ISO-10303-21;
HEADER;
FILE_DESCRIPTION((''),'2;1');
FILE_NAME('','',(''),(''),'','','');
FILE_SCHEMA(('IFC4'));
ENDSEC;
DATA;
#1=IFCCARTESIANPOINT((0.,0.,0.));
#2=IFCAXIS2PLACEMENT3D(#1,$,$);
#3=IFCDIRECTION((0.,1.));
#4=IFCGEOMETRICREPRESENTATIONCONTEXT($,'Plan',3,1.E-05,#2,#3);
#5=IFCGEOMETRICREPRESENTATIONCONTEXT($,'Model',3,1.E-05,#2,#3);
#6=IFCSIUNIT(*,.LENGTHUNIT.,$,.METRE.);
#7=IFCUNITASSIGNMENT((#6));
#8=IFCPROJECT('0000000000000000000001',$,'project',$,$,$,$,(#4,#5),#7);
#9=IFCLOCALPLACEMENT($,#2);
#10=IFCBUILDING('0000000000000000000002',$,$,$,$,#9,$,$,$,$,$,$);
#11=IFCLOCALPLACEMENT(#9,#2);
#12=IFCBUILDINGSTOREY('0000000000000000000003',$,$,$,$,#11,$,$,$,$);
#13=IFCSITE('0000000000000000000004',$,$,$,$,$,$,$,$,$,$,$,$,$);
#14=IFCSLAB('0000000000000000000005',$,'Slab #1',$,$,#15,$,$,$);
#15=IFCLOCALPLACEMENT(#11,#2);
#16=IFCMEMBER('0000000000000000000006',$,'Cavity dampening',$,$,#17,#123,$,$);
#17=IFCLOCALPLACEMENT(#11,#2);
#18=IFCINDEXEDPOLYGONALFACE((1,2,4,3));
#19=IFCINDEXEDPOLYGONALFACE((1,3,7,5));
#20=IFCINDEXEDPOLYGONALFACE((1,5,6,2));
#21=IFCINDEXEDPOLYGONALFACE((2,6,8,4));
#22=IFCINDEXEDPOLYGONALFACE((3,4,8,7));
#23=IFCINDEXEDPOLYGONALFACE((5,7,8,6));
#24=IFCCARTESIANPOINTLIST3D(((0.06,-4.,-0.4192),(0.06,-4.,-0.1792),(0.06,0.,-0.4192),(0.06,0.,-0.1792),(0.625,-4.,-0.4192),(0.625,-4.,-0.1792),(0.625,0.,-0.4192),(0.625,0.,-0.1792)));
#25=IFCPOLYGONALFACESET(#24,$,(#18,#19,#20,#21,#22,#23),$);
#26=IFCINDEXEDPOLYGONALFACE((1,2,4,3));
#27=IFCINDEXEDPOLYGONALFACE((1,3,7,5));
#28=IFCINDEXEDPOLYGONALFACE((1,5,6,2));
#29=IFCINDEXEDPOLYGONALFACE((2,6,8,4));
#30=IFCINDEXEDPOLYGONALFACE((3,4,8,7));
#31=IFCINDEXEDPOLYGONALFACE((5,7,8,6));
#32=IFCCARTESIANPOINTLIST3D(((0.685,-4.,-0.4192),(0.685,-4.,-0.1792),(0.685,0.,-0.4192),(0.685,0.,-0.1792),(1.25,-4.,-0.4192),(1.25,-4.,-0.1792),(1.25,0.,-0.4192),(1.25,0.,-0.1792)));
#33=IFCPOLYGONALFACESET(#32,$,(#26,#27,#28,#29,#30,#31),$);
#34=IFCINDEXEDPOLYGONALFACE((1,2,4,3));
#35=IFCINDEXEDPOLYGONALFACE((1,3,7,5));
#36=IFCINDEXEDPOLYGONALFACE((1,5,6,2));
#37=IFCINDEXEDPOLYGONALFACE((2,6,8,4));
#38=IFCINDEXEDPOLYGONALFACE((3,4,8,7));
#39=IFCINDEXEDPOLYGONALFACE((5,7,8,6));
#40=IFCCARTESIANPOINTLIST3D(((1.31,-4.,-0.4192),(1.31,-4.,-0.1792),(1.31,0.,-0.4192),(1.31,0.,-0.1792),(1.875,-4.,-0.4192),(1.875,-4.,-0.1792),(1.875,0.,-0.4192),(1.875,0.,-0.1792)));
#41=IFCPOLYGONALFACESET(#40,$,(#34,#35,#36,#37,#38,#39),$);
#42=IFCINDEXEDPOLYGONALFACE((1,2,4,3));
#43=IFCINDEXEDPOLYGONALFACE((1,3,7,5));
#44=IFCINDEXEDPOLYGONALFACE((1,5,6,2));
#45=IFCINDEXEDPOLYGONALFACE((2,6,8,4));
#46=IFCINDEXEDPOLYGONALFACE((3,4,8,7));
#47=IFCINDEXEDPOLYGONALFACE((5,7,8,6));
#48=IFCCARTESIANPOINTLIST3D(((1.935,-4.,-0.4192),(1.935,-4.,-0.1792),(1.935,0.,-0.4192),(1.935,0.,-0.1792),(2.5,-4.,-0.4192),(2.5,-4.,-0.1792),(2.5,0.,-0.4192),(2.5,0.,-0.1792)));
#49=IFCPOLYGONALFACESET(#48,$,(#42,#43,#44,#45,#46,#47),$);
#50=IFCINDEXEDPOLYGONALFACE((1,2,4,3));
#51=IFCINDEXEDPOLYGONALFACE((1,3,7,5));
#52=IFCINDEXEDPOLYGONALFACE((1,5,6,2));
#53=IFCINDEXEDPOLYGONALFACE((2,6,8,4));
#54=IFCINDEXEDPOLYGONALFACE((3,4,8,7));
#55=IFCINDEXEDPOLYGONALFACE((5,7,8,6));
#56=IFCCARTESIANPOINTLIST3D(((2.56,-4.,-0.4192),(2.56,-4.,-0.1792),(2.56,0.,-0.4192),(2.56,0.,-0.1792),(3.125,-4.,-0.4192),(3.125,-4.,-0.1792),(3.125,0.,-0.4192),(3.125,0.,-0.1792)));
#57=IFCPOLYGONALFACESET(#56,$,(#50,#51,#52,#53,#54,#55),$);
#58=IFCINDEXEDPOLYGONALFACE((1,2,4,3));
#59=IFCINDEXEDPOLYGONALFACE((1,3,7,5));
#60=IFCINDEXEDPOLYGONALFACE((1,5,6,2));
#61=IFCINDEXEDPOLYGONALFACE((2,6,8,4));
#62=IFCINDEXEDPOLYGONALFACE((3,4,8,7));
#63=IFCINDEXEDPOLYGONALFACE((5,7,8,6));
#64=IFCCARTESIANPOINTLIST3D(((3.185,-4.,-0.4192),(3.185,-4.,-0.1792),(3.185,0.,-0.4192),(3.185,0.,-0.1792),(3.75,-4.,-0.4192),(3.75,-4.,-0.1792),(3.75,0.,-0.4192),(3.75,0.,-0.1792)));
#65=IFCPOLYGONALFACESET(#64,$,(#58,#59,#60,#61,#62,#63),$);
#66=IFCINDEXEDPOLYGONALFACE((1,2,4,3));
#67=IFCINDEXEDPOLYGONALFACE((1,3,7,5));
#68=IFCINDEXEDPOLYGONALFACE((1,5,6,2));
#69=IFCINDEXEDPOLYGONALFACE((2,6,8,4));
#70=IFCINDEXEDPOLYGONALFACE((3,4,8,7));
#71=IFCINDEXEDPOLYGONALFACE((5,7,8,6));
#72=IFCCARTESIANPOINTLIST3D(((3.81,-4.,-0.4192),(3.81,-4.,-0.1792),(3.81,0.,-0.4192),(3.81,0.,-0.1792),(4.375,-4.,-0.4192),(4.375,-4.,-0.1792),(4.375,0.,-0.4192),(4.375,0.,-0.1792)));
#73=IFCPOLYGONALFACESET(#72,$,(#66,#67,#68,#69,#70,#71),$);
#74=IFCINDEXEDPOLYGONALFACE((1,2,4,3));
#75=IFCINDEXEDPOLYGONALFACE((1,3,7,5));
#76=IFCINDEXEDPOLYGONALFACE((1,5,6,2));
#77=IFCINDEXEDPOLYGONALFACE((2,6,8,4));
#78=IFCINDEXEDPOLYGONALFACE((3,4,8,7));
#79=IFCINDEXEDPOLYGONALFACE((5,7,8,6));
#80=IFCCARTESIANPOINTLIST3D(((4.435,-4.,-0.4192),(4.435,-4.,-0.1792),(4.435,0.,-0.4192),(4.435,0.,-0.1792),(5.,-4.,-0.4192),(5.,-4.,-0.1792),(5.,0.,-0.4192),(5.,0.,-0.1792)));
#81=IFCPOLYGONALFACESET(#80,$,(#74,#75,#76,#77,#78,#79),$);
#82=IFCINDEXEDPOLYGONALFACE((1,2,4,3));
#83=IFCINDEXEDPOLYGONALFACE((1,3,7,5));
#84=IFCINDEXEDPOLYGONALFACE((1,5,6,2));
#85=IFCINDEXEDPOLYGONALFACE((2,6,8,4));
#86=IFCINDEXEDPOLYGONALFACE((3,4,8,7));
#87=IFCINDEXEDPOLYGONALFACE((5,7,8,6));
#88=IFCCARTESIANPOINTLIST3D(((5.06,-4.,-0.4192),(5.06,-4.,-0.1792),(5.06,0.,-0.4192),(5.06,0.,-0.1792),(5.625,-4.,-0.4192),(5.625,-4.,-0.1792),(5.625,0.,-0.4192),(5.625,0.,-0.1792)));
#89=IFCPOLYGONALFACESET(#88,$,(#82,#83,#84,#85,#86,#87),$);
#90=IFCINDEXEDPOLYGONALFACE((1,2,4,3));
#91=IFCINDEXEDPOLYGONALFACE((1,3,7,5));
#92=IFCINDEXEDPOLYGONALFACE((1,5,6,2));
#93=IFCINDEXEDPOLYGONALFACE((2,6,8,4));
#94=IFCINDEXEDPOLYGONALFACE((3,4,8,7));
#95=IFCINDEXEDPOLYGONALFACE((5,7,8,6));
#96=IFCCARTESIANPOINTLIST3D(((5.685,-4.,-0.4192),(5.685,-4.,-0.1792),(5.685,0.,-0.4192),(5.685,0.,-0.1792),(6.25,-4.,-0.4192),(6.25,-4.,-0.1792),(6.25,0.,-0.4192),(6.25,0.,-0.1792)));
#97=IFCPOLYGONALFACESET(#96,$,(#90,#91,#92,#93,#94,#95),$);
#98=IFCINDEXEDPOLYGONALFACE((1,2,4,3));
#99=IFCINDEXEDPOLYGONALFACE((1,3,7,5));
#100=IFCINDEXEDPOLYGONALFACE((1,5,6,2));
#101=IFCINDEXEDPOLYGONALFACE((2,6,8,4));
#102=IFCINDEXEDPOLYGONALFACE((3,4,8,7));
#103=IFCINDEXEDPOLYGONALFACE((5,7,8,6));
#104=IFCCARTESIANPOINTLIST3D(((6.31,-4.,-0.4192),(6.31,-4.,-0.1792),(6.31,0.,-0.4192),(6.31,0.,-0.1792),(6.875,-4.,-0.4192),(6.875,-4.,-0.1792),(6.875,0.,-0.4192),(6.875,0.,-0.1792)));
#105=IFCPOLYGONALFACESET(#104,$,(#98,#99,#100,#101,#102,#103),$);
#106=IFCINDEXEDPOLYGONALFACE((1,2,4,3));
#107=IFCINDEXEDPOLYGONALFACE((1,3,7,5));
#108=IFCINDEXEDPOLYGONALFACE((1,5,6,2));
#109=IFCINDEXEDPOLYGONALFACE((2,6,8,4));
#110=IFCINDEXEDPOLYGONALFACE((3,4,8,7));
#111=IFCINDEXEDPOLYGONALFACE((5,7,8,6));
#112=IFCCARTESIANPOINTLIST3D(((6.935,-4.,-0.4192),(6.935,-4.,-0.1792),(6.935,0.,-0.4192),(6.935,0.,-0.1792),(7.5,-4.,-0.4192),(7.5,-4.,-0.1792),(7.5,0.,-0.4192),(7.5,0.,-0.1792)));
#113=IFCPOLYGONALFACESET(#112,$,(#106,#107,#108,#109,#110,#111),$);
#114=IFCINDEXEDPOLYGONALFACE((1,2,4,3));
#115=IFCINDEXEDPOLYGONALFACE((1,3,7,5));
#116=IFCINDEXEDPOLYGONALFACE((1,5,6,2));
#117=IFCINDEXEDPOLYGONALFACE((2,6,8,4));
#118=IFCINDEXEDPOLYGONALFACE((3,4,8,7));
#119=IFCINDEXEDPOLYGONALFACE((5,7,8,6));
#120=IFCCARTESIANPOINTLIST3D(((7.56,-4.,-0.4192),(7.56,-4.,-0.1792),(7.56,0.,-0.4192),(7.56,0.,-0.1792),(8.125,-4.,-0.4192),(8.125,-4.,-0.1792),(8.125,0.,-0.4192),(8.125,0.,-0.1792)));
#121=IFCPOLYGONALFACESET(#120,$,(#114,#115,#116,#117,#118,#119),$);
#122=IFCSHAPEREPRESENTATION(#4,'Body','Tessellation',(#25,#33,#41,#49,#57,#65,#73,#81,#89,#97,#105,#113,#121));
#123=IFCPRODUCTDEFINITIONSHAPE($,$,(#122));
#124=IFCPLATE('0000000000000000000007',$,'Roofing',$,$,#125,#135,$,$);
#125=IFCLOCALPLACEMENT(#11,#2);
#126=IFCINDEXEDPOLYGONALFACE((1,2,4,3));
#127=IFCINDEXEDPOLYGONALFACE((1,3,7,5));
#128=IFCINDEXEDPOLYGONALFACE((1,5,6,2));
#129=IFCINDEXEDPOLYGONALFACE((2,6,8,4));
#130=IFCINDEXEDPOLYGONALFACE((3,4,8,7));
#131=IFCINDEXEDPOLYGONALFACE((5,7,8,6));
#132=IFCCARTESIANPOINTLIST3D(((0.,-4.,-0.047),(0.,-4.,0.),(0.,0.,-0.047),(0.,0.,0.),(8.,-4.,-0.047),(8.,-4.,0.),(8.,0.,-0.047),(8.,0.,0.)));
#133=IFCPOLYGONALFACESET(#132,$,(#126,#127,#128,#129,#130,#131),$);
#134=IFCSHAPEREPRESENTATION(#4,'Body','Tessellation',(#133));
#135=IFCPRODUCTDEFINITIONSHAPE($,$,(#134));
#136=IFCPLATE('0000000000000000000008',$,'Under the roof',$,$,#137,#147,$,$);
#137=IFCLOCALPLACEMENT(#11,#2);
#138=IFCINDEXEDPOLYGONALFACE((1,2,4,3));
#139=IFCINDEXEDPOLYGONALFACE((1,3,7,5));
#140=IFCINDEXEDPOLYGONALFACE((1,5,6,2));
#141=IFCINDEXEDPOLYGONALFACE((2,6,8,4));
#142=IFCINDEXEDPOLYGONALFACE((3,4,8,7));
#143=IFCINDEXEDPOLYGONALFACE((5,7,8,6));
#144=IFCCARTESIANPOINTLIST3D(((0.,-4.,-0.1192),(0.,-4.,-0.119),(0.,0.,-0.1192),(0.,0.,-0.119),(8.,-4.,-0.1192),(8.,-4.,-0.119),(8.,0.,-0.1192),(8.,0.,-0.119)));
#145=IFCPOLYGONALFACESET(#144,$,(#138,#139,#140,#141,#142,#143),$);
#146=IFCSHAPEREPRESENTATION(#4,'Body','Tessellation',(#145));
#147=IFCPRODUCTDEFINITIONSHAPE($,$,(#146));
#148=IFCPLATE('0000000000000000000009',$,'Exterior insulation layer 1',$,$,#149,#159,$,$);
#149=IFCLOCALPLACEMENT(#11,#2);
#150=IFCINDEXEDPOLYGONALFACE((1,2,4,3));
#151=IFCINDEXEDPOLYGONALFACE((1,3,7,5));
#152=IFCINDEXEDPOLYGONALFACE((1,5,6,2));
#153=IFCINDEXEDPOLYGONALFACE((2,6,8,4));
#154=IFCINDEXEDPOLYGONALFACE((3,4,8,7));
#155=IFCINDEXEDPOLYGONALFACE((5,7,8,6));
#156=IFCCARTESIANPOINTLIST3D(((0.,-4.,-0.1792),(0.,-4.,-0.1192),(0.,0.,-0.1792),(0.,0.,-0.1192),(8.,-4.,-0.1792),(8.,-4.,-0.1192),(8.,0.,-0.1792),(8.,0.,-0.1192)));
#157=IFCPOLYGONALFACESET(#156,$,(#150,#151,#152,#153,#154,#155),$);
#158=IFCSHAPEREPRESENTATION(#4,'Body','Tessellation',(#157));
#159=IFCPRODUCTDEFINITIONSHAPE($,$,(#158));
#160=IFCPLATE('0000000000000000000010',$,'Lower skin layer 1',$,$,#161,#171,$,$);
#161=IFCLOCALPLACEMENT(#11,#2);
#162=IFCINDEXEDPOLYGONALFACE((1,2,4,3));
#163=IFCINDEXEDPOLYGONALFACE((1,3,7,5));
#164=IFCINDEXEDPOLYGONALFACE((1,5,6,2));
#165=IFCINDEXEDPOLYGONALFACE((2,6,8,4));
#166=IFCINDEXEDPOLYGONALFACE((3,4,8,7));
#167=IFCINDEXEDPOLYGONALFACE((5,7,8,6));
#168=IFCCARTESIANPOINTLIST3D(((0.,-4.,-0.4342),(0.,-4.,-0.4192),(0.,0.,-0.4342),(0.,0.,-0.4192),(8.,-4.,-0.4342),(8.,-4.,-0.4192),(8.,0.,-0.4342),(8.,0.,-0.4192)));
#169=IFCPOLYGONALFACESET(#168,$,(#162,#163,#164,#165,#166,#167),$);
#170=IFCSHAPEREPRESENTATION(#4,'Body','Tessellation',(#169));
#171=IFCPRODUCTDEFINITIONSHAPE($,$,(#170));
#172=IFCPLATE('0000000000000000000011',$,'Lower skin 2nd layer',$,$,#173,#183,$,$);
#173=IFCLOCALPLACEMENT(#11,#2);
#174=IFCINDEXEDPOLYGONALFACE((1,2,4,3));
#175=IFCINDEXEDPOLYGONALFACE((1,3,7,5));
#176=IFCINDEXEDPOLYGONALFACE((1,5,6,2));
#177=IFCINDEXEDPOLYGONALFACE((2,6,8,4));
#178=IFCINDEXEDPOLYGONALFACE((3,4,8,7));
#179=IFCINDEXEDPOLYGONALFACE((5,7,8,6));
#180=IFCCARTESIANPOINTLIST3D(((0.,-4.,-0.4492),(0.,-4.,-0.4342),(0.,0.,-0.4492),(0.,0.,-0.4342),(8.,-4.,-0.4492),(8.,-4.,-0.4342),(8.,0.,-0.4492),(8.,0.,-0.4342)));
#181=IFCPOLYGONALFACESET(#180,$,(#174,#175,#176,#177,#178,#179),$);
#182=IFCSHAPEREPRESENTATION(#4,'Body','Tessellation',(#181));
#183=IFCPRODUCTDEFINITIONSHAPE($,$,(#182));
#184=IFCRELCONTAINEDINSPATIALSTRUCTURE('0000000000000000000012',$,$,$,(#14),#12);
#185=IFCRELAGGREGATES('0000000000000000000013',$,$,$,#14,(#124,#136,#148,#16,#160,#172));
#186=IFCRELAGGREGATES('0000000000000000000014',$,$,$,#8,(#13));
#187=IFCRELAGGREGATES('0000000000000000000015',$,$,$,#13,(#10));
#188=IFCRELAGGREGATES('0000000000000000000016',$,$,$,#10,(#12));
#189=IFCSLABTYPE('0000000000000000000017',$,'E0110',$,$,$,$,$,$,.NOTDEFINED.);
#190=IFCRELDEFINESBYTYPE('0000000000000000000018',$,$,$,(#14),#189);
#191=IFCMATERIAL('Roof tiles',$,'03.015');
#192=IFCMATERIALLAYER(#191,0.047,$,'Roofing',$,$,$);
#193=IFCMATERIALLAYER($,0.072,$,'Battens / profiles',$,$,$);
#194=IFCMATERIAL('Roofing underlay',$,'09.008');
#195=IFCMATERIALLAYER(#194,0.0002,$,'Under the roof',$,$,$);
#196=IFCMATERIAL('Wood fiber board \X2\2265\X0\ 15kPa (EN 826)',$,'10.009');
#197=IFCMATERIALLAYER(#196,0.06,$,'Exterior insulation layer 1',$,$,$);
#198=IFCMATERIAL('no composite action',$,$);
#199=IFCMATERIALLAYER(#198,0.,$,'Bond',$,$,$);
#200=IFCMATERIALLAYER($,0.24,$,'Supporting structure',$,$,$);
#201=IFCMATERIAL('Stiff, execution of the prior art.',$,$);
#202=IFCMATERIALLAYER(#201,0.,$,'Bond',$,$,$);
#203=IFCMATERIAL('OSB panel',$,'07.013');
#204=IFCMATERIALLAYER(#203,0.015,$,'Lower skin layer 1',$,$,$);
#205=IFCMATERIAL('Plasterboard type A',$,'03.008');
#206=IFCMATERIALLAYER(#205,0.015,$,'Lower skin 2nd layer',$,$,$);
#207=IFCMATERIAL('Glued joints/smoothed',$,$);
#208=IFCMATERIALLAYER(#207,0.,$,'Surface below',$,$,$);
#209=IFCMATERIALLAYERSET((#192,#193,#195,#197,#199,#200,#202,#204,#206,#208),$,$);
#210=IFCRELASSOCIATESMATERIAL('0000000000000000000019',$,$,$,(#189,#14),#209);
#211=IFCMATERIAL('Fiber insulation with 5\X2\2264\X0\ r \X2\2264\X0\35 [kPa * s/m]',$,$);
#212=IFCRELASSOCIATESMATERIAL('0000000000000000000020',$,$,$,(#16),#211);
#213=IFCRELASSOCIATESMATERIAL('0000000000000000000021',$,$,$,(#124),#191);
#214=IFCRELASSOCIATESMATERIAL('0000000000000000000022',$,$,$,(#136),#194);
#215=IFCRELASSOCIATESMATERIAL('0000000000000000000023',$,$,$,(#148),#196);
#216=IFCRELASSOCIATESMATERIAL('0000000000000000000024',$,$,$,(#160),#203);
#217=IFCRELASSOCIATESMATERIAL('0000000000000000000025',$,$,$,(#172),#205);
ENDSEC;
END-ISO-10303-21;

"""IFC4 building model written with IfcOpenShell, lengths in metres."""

from ifc_helpers import new_model, si_unit, direction, frame, frame_2d, origin, origin_with_axes, place, context, project, spatial, rectangle, extrude, material, layer, layer_set, type_object, element, aggregate, save


model = new_model("IFC4")

# Units and contexts
plan_context = context("Plan", 3, precision=1e-05, world=origin(), true_north=direction((0.0, 1.0)))
model_context = context("Model", 3, precision=1e-05, world=origin(), true_north=direction((0.0, 1.0)))
ifc_project = project(units=[si_unit("LENGTHUNIT", "METRE")], contexts=[plan_context, model_context])

# Site, building, storey
site = spatial("IfcSite", under=ifc_project)
building_placement = place(None, origin())
building = spatial("IfcBuilding", under=site, at=building_placement)
storey_placement = place(building_placement, origin())
storey = spatial("IfcBuildingStorey", under=building, at=storey_placement)

# Slab, member, plates
ifc_material_1 = material(Name="Roof tiles", Category="03.015")
ifc_layer_1 = layer(ifc_material_1, 0.047, Name="Roofing")
ifc_layer_2 = layer(None, 0.072, Name="Battens / profiles")
ifc_material_2 = material(Name="Roofing underlay", Category="09.008")
ifc_layer_3 = layer(ifc_material_2, 0.0002, Name="Under the roof")
ifc_material_3 = material(Name="Wood fiber board ≥ 15kPa (EN 826)", Category="10.009")
ifc_layer_4 = layer(ifc_material_3, 0.06, Name="Exterior insulation layer 1")
ifc_material_4 = material(Name="no composite action")
ifc_layer_5 = layer(ifc_material_4, 0.0, Name="Bond")
ifc_layer_6 = layer(None, 0.24, Name="Supporting structure")
ifc_material_5 = material(Name="Stiff, execution of the prior art.")
ifc_layer_7 = layer(ifc_material_5, 0.0, Name="Bond")
ifc_material_6 = material(Name="OSB panel", Category="07.013")
ifc_layer_8 = layer(ifc_material_6, 0.015, Name="Lower skin layer 1")
ifc_material_7 = material(Name="Plasterboard type A", Category="03.008")
ifc_layer_9 = layer(ifc_material_7, 0.015, Name="Lower skin 2nd layer")
ifc_material_8 = material(Name="Glued joints/smoothed")
ifc_layer_10 = layer(ifc_material_8, 0.0, Name="Surface below")
ifc_layer_set = layer_set([ifc_layer_1, ifc_layer_2, ifc_layer_3, ifc_layer_4, ifc_layer_5, ifc_layer_6, ifc_layer_7, ifc_layer_8, ifc_layer_9, ifc_layer_10])
slab_type = type_object("IfcSlabType", Name="E0110", PredefinedType="NOTDEFINED", material=ifc_layer_set)
slab_placement = place(None, frame((0.0, 0.0, 0.0), z_axis=(0.0, 0.0, -1.0), x_axis=(1.0, 0.0, 0.0)))
slab = element("IfcSlab", 1, at=slab_placement, inside=storey, type_object=slab_type, material=ifc_layer_set, Name="Slab #1")
ifc_material_9 = material(Name="Fiber insulation with 5≤ r ≤35 [kPa * s/m]")
member_1_placement = place(slab_placement, origin())
member_1 = element("IfcMember", 2, at=member_1_placement, material=ifc_material_9, Name="Cavity dampening", context=plan_context, shape_type="SweptSolid", body=[
    extrude(rectangle(XDim=0.565, YDim=0.24, at=frame_2d((0.2825, 0.12), x_axis=(1.0, 0.0))), frame((0.06, 4.0, 0.1792), z_axis=(0.0, -1.0, 0.0), x_axis=(1.0, 0.0, 0.0)), (0.0, 0.0, 1.0), 4.0),
    extrude(rectangle(XDim=0.565, YDim=0.24, at=frame_2d((0.2825, 0.12), x_axis=(1.0, 0.0))), frame((0.685, 4.0, 0.1792), z_axis=(0.0, -1.0, 0.0), x_axis=(1.0, 0.0, 0.0)), (0.0, 0.0, 1.0), 4.0),
    extrude(rectangle(XDim=0.565, YDim=0.24, at=frame_2d((0.2825, 0.12), x_axis=(1.0, 0.0))), frame((1.31, 4.0, 0.1792), z_axis=(0.0, -1.0, 0.0), x_axis=(1.0, 0.0, 0.0)), (0.0, 0.0, 1.0), 4.0),
    extrude(rectangle(XDim=0.565, YDim=0.24, at=frame_2d((0.2825, 0.12), x_axis=(1.0, 0.0))), frame((1.935, 4.0, 0.1792), z_axis=(0.0, -1.0, 0.0), x_axis=(1.0, 0.0, 0.0)), (0.0, 0.0, 1.0), 4.0),
    extrude(rectangle(XDim=0.565, YDim=0.24, at=frame_2d((0.2825, 0.12), x_axis=(1.0, 0.0))), frame((2.56, 4.0, 0.1792), z_axis=(0.0, -1.0, 0.0), x_axis=(1.0, 0.0, 0.0)), (0.0, 0.0, 1.0), 4.0),
    extrude(rectangle(XDim=0.565, YDim=0.24, at=frame_2d((0.2825, 0.12), x_axis=(1.0, 0.0))), frame((3.185, 4.0, 0.1792), z_axis=(0.0, -1.0, 0.0), x_axis=(1.0, 0.0, 0.0)), (0.0, 0.0, 1.0), 4.0),
    extrude(rectangle(XDim=0.565, YDim=0.24, at=frame_2d((0.2825, 0.12), x_axis=(1.0, 0.0))), frame((3.81, 4.0, 0.1792), z_axis=(0.0, -1.0, 0.0), x_axis=(1.0, 0.0, 0.0)), (0.0, 0.0, 1.0), 4.0),
    extrude(rectangle(XDim=0.565, YDim=0.24, at=frame_2d((0.2825, 0.12), x_axis=(1.0, 0.0))), frame((4.435, 4.0, 0.1792), z_axis=(0.0, -1.0, 0.0), x_axis=(1.0, 0.0, 0.0)), (0.0, 0.0, 1.0), 4.0),
    extrude(rectangle(XDim=0.565, YDim=0.24, at=frame_2d((0.2825, 0.12), x_axis=(1.0, 0.0))), frame((5.06, 4.0, 0.1792), z_axis=(0.0, -1.0, 0.0), x_axis=(1.0, 0.0, 0.0)), (0.0, 0.0, 1.0), 4.0),
    extrude(rectangle(XDim=0.565, YDim=0.24, at=frame_2d((0.2825, 0.12), x_axis=(1.0, 0.0))), frame((5.685, 4.0, 0.1792), z_axis=(0.0, -1.0, 0.0), x_axis=(1.0, 0.0, 0.0)), (0.0, 0.0, 1.0), 4.0),
    extrude(rectangle(XDim=0.565, YDim=0.24, at=frame_2d((0.2825, 0.12), x_axis=(1.0, 0.0))), frame((6.31, 4.0, 0.1792), z_axis=(0.0, -1.0, 0.0), x_axis=(1.0, 0.0, 0.0)), (0.0, 0.0, 1.0), 4.0),
    extrude(rectangle(XDim=0.565, YDim=0.24, at=frame_2d((0.2825, 0.12), x_axis=(1.0, 0.0))), frame((6.935, 4.0, 0.1792), z_axis=(0.0, -1.0, 0.0), x_axis=(1.0, 0.0, 0.0)), (0.0, 0.0, 1.0), 4.0),
    extrude(rectangle(XDim=0.565, YDim=0.24, at=frame_2d((0.2825, 0.12), x_axis=(1.0, 0.0))), frame((7.56, 4.0, 0.1792), z_axis=(0.0, -1.0, 0.0), x_axis=(1.0, 0.0, 0.0)), (0.0, 0.0, 1.0), 4.0),
])
plate_1_placement = place(slab_placement, origin())
plate_1 = element("IfcPlate", 3, at=plate_1_placement, material=ifc_material_1, Name="Roofing", context=plan_context, shape_type="SweptSolid", body=[
    extrude(rectangle(XDim=8.0, YDim=4.0, at=frame_2d((4.0, 2.0), x_axis=(1.0, 0.0))), origin_with_axes(), (0.0, 0.0, 1.0), 0.047),
])
plate_2_placement = place(slab_placement, origin())
plate_2 = element("IfcPlate", 4, at=plate_2_placement, material=ifc_material_2, Name="Under the roof", context=plan_context, shape_type="SweptSolid", body=[
    extrude(rectangle(XDim=8.0, YDim=4.0, at=frame_2d((4.0, 2.0), x_axis=(1.0, 0.0))), frame((0.0, 0.0, 0.119), z_axis=(0.0, 0.0, 1.0), x_axis=(1.0, 0.0, 0.0)), (0.0, 0.0, 1.0), 0.0002),
])
plate_3_placement = place(slab_placement, origin())
plate_3 = element("IfcPlate", 5, at=plate_3_placement, material=ifc_material_3, Name="Exterior insulation layer 1", context=plan_context, shape_type="SweptSolid", body=[
    extrude(rectangle(XDim=8.0, YDim=4.0, at=frame_2d((4.0, 2.0), x_axis=(1.0, 0.0))), frame((0.0, 0.0, 0.1192), z_axis=(0.0, 0.0, 1.0), x_axis=(1.0, 0.0, 0.0)), (0.0, 0.0, 1.0), 0.06),
])
plate_4_placement = place(slab_placement, origin())
plate_4 = element("IfcPlate", 6, at=plate_4_placement, material=ifc_material_6, Name="Lower skin layer 1", context=plan_context, shape_type="SweptSolid", body=[
    extrude(rectangle(XDim=8.0, YDim=4.0, at=frame_2d((4.0, 2.0), x_axis=(1.0, 0.0))), frame((0.0, 0.0, 0.4192), z_axis=(0.0, 0.0, 1.0), x_axis=(1.0, 0.0, 0.0)), (0.0, 0.0, 1.0), 0.015),
])
plate_5_placement = place(slab_placement, origin())
plate_5 = element("IfcPlate", 7, at=plate_5_placement, material=ifc_material_7, Name="Lower skin 2nd layer", context=plan_context, shape_type="SweptSolid", body=[
    extrude(rectangle(XDim=8.0, YDim=4.0, at=frame_2d((4.0, 2.0), x_axis=(1.0, 0.0))), frame((0.0, 0.0, 0.4342), z_axis=(0.0, 0.0, 1.0), x_axis=(1.0, 0.0, 0.0)), (0.0, 0.0, 1.0), 0.015),
])
aggregate(slab, [plate_1, plate_2, plate_3, member_1, plate_4, plate_5])

save(model, "model.ifc")
